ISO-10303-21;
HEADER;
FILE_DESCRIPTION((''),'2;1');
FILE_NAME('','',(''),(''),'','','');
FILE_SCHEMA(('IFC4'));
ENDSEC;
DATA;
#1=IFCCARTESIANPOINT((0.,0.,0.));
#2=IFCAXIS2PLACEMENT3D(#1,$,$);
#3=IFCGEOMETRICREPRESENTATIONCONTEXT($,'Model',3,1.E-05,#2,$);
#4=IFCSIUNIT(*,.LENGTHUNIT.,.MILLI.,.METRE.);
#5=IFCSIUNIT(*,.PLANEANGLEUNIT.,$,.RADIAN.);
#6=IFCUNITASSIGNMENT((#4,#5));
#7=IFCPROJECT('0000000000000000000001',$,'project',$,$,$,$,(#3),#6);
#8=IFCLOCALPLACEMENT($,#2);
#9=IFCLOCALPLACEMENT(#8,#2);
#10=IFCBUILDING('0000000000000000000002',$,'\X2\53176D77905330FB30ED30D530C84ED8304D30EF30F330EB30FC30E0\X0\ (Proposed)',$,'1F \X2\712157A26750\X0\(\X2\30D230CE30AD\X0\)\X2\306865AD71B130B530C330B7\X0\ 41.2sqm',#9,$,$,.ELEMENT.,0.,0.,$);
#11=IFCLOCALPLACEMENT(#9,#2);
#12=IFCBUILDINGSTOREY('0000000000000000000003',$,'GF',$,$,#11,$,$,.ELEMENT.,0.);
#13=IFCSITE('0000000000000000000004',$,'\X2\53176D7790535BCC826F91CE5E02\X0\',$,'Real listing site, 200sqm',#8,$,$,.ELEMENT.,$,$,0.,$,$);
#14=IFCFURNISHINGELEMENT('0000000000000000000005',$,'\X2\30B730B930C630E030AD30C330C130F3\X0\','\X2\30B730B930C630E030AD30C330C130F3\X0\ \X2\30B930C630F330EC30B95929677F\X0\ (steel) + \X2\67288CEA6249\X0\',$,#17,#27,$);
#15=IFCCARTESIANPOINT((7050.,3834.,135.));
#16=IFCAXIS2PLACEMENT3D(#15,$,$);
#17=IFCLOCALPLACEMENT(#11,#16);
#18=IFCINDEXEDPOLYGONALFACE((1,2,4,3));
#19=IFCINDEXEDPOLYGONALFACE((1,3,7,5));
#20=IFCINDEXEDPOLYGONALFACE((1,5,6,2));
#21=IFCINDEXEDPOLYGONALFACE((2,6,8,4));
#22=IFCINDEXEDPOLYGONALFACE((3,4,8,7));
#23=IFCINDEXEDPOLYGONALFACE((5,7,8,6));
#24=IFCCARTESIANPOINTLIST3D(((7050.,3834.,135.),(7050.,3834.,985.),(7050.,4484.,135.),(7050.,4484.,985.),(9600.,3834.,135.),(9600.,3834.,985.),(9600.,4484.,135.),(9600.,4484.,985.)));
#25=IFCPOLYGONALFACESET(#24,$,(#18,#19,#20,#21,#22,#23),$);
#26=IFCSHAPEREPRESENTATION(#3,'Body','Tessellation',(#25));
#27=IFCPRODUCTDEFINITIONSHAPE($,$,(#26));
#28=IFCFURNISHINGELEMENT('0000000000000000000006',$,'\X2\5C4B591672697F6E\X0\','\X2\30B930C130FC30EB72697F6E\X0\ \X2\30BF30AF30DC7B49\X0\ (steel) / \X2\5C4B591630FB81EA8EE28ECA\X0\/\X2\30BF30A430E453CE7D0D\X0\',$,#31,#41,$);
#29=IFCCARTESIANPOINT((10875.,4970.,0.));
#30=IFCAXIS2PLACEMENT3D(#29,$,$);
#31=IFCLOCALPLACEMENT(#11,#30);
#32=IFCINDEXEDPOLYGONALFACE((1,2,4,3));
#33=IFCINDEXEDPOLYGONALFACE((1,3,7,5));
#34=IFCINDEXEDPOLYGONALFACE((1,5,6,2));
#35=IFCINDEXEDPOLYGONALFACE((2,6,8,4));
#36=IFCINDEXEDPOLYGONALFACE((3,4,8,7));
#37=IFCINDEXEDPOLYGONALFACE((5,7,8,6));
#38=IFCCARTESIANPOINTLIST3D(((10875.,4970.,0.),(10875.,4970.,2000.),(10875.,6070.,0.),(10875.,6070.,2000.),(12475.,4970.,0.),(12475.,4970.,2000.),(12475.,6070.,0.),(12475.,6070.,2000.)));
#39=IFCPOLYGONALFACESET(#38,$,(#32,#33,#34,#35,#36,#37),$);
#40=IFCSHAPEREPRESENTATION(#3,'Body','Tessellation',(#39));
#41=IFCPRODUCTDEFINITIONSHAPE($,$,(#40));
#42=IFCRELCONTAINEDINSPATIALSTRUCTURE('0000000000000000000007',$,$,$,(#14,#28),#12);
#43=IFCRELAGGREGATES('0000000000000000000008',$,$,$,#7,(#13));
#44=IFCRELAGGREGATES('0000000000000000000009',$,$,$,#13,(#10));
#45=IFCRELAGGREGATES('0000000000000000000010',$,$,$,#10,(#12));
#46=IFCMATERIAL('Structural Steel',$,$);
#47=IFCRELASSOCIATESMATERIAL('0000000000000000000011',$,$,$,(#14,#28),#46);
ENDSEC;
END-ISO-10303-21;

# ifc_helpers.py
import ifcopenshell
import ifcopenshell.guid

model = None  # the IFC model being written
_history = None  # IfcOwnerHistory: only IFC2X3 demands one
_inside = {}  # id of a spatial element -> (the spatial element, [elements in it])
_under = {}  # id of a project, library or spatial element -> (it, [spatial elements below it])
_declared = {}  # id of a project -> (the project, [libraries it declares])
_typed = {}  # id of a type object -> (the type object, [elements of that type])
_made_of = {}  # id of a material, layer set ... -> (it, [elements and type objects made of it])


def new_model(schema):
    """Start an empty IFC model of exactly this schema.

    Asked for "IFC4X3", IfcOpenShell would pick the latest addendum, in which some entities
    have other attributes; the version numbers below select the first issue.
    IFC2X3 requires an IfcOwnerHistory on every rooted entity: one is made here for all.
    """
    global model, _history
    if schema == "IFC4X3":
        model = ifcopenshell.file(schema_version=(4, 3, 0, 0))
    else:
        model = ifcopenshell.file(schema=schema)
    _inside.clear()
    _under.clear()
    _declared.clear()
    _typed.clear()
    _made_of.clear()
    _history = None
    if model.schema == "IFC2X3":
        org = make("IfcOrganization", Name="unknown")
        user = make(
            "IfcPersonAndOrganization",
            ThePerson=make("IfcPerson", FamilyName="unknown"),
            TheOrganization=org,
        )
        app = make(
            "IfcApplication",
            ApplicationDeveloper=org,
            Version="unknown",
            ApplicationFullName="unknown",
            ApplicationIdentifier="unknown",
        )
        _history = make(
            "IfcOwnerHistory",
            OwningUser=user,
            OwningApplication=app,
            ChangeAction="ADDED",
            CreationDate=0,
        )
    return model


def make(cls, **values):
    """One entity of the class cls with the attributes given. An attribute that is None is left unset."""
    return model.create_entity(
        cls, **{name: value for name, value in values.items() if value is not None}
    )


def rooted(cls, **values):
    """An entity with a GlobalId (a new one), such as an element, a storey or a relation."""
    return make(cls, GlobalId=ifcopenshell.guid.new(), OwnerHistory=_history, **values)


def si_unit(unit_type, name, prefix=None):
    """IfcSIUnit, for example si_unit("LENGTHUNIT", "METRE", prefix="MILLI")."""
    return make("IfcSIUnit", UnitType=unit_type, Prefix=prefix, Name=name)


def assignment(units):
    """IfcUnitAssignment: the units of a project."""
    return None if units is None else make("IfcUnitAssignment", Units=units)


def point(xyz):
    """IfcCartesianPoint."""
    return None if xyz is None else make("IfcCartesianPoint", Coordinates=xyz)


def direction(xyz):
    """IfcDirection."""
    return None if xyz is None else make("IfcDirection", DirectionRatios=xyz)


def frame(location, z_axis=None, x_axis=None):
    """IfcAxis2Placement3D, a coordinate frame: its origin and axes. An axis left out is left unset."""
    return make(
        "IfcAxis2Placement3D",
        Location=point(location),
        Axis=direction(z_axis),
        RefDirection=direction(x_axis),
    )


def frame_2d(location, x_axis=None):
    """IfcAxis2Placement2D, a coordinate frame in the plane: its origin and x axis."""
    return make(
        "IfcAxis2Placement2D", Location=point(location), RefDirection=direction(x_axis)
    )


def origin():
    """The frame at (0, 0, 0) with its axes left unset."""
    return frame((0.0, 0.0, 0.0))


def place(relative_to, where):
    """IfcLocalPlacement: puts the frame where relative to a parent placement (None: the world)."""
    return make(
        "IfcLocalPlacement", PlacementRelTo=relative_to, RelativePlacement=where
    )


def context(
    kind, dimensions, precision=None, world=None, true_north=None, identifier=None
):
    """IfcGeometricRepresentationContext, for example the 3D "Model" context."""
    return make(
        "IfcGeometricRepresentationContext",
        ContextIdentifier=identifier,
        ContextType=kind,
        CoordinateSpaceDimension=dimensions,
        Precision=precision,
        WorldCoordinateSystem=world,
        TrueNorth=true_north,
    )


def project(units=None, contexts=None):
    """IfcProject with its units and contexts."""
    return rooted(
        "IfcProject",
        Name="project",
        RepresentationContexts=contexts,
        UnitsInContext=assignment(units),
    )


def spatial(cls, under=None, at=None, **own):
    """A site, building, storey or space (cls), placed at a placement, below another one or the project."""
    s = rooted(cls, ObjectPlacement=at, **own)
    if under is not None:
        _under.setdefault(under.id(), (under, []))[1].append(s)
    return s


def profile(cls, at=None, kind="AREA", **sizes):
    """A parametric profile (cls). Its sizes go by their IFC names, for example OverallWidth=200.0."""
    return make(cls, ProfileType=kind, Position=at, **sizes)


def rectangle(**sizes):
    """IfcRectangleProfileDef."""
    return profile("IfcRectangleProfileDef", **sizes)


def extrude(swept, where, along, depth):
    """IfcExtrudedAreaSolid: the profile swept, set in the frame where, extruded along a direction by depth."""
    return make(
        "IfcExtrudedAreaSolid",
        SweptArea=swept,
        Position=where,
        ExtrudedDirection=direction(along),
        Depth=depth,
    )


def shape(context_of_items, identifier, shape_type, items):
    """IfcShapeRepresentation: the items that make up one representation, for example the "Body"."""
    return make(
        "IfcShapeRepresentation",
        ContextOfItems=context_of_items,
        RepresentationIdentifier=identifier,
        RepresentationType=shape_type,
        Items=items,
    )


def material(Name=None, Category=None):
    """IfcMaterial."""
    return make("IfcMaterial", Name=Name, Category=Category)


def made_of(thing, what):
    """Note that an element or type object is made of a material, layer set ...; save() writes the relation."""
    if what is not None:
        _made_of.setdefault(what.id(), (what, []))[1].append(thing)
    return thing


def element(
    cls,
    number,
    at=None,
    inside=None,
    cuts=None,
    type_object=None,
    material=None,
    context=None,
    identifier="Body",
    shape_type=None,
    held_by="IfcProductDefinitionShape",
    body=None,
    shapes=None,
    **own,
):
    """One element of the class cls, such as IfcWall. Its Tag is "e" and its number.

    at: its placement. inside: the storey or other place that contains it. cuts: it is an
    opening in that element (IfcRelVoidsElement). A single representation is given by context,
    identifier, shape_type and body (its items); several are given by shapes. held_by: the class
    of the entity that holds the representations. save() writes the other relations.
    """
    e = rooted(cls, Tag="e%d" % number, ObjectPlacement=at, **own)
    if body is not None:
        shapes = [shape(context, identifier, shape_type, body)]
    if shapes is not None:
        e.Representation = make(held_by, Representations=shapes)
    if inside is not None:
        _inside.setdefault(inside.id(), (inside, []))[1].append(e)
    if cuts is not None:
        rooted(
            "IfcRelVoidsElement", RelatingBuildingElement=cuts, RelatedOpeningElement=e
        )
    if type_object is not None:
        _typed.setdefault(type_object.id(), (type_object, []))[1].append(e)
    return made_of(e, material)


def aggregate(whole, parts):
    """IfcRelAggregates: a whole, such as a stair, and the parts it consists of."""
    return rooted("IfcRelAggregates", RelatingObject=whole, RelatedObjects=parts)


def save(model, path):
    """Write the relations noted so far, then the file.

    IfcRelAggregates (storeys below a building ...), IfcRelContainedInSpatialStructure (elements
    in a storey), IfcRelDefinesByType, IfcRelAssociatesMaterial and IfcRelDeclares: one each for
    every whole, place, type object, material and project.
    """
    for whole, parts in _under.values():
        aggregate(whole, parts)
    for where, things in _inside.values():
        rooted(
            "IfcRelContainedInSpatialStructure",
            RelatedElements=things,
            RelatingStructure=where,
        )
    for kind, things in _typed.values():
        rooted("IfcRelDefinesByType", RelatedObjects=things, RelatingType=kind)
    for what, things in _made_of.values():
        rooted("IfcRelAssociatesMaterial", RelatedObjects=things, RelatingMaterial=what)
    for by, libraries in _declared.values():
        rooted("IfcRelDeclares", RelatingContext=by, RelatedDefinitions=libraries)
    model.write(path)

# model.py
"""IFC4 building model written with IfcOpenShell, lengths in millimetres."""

from ifc_helpers import new_model, si_unit, frame, frame_2d, origin, place, context, project, spatial, rectangle, extrude, material, element, save


model = new_model("IFC4")

# Units and contexts
model_context = context("Model", 3, precision=1e-05, world=origin())
ifc_project = project(units=[si_unit("LENGTHUNIT", "METRE", prefix="MILLI"), si_unit("PLANEANGLEUNIT", "RADIAN")], contexts=[model_context])

# Site, building, storey
site_placement = place(None, origin())
site = spatial("IfcSite", under=ifc_project, at=site_placement, Name="北海道富良野市", ObjectType="Real listing site, 200sqm", CompositionType="ELEMENT", RefElevation=0.0)
building_placement = place(site_placement, origin())
building = spatial("IfcBuilding", under=site, at=building_placement, Name="北海道・ロフト付きワンルーム (Proposed)", ObjectType="1F 無垢材(ヒノキ)と断熱サッシ 41.2sqm", CompositionType="ELEMENT", ElevationOfRefHeight=0.0, ElevationOfTerrain=0.0)
storey_placement = place(building_placement, origin())
storey = spatial("IfcBuildingStorey", under=building, at=storey_placement, Name="GF", CompositionType="ELEMENT", Elevation=0.0)

# Shared definitions
ifc_material_1 = material(Name="Structural Steel")

# Furnishing elements
furnishing_1_placement = place(storey_placement, frame((7050.0, 3834.0, 135.0)))
element("IfcFurnishingElement", 1, at=furnishing_1_placement, inside=storey, material=ifc_material_1, Name="システムキッチン", Description="システムキッチン ステンレス天板 (steel) + 木質扉", context=model_context, shape_type="SweptSolid", body=[
    extrude(rectangle(XDim=2550.0, YDim=650.0, at=frame_2d((1275.0, 325.0))), frame((7050.0, 3834.0, 135.0)), (0.0, 0.0, 1.0), 850.0),
])
furnishing_2_placement = place(storey_placement, frame((10875.0, 4970.0, 0.0)))
element("IfcFurnishingElement", 2, at=furnishing_2_placement, inside=storey, material=ifc_material_1, Name="屋外物置", Description="スチール物置 タクボ等 (steel) / 屋外・自転車/タイヤ収納", context=model_context, shape_type="SweptSolid", body=[
    extrude(rectangle(XDim=1600.0, YDim=1100.0, at=frame_2d((800.0, 550.0))), frame((10875.0, 4970.0, 0.0)), (0.0, 0.0, 1.0), 2000.0),
])

save(model, "model.ifc")
